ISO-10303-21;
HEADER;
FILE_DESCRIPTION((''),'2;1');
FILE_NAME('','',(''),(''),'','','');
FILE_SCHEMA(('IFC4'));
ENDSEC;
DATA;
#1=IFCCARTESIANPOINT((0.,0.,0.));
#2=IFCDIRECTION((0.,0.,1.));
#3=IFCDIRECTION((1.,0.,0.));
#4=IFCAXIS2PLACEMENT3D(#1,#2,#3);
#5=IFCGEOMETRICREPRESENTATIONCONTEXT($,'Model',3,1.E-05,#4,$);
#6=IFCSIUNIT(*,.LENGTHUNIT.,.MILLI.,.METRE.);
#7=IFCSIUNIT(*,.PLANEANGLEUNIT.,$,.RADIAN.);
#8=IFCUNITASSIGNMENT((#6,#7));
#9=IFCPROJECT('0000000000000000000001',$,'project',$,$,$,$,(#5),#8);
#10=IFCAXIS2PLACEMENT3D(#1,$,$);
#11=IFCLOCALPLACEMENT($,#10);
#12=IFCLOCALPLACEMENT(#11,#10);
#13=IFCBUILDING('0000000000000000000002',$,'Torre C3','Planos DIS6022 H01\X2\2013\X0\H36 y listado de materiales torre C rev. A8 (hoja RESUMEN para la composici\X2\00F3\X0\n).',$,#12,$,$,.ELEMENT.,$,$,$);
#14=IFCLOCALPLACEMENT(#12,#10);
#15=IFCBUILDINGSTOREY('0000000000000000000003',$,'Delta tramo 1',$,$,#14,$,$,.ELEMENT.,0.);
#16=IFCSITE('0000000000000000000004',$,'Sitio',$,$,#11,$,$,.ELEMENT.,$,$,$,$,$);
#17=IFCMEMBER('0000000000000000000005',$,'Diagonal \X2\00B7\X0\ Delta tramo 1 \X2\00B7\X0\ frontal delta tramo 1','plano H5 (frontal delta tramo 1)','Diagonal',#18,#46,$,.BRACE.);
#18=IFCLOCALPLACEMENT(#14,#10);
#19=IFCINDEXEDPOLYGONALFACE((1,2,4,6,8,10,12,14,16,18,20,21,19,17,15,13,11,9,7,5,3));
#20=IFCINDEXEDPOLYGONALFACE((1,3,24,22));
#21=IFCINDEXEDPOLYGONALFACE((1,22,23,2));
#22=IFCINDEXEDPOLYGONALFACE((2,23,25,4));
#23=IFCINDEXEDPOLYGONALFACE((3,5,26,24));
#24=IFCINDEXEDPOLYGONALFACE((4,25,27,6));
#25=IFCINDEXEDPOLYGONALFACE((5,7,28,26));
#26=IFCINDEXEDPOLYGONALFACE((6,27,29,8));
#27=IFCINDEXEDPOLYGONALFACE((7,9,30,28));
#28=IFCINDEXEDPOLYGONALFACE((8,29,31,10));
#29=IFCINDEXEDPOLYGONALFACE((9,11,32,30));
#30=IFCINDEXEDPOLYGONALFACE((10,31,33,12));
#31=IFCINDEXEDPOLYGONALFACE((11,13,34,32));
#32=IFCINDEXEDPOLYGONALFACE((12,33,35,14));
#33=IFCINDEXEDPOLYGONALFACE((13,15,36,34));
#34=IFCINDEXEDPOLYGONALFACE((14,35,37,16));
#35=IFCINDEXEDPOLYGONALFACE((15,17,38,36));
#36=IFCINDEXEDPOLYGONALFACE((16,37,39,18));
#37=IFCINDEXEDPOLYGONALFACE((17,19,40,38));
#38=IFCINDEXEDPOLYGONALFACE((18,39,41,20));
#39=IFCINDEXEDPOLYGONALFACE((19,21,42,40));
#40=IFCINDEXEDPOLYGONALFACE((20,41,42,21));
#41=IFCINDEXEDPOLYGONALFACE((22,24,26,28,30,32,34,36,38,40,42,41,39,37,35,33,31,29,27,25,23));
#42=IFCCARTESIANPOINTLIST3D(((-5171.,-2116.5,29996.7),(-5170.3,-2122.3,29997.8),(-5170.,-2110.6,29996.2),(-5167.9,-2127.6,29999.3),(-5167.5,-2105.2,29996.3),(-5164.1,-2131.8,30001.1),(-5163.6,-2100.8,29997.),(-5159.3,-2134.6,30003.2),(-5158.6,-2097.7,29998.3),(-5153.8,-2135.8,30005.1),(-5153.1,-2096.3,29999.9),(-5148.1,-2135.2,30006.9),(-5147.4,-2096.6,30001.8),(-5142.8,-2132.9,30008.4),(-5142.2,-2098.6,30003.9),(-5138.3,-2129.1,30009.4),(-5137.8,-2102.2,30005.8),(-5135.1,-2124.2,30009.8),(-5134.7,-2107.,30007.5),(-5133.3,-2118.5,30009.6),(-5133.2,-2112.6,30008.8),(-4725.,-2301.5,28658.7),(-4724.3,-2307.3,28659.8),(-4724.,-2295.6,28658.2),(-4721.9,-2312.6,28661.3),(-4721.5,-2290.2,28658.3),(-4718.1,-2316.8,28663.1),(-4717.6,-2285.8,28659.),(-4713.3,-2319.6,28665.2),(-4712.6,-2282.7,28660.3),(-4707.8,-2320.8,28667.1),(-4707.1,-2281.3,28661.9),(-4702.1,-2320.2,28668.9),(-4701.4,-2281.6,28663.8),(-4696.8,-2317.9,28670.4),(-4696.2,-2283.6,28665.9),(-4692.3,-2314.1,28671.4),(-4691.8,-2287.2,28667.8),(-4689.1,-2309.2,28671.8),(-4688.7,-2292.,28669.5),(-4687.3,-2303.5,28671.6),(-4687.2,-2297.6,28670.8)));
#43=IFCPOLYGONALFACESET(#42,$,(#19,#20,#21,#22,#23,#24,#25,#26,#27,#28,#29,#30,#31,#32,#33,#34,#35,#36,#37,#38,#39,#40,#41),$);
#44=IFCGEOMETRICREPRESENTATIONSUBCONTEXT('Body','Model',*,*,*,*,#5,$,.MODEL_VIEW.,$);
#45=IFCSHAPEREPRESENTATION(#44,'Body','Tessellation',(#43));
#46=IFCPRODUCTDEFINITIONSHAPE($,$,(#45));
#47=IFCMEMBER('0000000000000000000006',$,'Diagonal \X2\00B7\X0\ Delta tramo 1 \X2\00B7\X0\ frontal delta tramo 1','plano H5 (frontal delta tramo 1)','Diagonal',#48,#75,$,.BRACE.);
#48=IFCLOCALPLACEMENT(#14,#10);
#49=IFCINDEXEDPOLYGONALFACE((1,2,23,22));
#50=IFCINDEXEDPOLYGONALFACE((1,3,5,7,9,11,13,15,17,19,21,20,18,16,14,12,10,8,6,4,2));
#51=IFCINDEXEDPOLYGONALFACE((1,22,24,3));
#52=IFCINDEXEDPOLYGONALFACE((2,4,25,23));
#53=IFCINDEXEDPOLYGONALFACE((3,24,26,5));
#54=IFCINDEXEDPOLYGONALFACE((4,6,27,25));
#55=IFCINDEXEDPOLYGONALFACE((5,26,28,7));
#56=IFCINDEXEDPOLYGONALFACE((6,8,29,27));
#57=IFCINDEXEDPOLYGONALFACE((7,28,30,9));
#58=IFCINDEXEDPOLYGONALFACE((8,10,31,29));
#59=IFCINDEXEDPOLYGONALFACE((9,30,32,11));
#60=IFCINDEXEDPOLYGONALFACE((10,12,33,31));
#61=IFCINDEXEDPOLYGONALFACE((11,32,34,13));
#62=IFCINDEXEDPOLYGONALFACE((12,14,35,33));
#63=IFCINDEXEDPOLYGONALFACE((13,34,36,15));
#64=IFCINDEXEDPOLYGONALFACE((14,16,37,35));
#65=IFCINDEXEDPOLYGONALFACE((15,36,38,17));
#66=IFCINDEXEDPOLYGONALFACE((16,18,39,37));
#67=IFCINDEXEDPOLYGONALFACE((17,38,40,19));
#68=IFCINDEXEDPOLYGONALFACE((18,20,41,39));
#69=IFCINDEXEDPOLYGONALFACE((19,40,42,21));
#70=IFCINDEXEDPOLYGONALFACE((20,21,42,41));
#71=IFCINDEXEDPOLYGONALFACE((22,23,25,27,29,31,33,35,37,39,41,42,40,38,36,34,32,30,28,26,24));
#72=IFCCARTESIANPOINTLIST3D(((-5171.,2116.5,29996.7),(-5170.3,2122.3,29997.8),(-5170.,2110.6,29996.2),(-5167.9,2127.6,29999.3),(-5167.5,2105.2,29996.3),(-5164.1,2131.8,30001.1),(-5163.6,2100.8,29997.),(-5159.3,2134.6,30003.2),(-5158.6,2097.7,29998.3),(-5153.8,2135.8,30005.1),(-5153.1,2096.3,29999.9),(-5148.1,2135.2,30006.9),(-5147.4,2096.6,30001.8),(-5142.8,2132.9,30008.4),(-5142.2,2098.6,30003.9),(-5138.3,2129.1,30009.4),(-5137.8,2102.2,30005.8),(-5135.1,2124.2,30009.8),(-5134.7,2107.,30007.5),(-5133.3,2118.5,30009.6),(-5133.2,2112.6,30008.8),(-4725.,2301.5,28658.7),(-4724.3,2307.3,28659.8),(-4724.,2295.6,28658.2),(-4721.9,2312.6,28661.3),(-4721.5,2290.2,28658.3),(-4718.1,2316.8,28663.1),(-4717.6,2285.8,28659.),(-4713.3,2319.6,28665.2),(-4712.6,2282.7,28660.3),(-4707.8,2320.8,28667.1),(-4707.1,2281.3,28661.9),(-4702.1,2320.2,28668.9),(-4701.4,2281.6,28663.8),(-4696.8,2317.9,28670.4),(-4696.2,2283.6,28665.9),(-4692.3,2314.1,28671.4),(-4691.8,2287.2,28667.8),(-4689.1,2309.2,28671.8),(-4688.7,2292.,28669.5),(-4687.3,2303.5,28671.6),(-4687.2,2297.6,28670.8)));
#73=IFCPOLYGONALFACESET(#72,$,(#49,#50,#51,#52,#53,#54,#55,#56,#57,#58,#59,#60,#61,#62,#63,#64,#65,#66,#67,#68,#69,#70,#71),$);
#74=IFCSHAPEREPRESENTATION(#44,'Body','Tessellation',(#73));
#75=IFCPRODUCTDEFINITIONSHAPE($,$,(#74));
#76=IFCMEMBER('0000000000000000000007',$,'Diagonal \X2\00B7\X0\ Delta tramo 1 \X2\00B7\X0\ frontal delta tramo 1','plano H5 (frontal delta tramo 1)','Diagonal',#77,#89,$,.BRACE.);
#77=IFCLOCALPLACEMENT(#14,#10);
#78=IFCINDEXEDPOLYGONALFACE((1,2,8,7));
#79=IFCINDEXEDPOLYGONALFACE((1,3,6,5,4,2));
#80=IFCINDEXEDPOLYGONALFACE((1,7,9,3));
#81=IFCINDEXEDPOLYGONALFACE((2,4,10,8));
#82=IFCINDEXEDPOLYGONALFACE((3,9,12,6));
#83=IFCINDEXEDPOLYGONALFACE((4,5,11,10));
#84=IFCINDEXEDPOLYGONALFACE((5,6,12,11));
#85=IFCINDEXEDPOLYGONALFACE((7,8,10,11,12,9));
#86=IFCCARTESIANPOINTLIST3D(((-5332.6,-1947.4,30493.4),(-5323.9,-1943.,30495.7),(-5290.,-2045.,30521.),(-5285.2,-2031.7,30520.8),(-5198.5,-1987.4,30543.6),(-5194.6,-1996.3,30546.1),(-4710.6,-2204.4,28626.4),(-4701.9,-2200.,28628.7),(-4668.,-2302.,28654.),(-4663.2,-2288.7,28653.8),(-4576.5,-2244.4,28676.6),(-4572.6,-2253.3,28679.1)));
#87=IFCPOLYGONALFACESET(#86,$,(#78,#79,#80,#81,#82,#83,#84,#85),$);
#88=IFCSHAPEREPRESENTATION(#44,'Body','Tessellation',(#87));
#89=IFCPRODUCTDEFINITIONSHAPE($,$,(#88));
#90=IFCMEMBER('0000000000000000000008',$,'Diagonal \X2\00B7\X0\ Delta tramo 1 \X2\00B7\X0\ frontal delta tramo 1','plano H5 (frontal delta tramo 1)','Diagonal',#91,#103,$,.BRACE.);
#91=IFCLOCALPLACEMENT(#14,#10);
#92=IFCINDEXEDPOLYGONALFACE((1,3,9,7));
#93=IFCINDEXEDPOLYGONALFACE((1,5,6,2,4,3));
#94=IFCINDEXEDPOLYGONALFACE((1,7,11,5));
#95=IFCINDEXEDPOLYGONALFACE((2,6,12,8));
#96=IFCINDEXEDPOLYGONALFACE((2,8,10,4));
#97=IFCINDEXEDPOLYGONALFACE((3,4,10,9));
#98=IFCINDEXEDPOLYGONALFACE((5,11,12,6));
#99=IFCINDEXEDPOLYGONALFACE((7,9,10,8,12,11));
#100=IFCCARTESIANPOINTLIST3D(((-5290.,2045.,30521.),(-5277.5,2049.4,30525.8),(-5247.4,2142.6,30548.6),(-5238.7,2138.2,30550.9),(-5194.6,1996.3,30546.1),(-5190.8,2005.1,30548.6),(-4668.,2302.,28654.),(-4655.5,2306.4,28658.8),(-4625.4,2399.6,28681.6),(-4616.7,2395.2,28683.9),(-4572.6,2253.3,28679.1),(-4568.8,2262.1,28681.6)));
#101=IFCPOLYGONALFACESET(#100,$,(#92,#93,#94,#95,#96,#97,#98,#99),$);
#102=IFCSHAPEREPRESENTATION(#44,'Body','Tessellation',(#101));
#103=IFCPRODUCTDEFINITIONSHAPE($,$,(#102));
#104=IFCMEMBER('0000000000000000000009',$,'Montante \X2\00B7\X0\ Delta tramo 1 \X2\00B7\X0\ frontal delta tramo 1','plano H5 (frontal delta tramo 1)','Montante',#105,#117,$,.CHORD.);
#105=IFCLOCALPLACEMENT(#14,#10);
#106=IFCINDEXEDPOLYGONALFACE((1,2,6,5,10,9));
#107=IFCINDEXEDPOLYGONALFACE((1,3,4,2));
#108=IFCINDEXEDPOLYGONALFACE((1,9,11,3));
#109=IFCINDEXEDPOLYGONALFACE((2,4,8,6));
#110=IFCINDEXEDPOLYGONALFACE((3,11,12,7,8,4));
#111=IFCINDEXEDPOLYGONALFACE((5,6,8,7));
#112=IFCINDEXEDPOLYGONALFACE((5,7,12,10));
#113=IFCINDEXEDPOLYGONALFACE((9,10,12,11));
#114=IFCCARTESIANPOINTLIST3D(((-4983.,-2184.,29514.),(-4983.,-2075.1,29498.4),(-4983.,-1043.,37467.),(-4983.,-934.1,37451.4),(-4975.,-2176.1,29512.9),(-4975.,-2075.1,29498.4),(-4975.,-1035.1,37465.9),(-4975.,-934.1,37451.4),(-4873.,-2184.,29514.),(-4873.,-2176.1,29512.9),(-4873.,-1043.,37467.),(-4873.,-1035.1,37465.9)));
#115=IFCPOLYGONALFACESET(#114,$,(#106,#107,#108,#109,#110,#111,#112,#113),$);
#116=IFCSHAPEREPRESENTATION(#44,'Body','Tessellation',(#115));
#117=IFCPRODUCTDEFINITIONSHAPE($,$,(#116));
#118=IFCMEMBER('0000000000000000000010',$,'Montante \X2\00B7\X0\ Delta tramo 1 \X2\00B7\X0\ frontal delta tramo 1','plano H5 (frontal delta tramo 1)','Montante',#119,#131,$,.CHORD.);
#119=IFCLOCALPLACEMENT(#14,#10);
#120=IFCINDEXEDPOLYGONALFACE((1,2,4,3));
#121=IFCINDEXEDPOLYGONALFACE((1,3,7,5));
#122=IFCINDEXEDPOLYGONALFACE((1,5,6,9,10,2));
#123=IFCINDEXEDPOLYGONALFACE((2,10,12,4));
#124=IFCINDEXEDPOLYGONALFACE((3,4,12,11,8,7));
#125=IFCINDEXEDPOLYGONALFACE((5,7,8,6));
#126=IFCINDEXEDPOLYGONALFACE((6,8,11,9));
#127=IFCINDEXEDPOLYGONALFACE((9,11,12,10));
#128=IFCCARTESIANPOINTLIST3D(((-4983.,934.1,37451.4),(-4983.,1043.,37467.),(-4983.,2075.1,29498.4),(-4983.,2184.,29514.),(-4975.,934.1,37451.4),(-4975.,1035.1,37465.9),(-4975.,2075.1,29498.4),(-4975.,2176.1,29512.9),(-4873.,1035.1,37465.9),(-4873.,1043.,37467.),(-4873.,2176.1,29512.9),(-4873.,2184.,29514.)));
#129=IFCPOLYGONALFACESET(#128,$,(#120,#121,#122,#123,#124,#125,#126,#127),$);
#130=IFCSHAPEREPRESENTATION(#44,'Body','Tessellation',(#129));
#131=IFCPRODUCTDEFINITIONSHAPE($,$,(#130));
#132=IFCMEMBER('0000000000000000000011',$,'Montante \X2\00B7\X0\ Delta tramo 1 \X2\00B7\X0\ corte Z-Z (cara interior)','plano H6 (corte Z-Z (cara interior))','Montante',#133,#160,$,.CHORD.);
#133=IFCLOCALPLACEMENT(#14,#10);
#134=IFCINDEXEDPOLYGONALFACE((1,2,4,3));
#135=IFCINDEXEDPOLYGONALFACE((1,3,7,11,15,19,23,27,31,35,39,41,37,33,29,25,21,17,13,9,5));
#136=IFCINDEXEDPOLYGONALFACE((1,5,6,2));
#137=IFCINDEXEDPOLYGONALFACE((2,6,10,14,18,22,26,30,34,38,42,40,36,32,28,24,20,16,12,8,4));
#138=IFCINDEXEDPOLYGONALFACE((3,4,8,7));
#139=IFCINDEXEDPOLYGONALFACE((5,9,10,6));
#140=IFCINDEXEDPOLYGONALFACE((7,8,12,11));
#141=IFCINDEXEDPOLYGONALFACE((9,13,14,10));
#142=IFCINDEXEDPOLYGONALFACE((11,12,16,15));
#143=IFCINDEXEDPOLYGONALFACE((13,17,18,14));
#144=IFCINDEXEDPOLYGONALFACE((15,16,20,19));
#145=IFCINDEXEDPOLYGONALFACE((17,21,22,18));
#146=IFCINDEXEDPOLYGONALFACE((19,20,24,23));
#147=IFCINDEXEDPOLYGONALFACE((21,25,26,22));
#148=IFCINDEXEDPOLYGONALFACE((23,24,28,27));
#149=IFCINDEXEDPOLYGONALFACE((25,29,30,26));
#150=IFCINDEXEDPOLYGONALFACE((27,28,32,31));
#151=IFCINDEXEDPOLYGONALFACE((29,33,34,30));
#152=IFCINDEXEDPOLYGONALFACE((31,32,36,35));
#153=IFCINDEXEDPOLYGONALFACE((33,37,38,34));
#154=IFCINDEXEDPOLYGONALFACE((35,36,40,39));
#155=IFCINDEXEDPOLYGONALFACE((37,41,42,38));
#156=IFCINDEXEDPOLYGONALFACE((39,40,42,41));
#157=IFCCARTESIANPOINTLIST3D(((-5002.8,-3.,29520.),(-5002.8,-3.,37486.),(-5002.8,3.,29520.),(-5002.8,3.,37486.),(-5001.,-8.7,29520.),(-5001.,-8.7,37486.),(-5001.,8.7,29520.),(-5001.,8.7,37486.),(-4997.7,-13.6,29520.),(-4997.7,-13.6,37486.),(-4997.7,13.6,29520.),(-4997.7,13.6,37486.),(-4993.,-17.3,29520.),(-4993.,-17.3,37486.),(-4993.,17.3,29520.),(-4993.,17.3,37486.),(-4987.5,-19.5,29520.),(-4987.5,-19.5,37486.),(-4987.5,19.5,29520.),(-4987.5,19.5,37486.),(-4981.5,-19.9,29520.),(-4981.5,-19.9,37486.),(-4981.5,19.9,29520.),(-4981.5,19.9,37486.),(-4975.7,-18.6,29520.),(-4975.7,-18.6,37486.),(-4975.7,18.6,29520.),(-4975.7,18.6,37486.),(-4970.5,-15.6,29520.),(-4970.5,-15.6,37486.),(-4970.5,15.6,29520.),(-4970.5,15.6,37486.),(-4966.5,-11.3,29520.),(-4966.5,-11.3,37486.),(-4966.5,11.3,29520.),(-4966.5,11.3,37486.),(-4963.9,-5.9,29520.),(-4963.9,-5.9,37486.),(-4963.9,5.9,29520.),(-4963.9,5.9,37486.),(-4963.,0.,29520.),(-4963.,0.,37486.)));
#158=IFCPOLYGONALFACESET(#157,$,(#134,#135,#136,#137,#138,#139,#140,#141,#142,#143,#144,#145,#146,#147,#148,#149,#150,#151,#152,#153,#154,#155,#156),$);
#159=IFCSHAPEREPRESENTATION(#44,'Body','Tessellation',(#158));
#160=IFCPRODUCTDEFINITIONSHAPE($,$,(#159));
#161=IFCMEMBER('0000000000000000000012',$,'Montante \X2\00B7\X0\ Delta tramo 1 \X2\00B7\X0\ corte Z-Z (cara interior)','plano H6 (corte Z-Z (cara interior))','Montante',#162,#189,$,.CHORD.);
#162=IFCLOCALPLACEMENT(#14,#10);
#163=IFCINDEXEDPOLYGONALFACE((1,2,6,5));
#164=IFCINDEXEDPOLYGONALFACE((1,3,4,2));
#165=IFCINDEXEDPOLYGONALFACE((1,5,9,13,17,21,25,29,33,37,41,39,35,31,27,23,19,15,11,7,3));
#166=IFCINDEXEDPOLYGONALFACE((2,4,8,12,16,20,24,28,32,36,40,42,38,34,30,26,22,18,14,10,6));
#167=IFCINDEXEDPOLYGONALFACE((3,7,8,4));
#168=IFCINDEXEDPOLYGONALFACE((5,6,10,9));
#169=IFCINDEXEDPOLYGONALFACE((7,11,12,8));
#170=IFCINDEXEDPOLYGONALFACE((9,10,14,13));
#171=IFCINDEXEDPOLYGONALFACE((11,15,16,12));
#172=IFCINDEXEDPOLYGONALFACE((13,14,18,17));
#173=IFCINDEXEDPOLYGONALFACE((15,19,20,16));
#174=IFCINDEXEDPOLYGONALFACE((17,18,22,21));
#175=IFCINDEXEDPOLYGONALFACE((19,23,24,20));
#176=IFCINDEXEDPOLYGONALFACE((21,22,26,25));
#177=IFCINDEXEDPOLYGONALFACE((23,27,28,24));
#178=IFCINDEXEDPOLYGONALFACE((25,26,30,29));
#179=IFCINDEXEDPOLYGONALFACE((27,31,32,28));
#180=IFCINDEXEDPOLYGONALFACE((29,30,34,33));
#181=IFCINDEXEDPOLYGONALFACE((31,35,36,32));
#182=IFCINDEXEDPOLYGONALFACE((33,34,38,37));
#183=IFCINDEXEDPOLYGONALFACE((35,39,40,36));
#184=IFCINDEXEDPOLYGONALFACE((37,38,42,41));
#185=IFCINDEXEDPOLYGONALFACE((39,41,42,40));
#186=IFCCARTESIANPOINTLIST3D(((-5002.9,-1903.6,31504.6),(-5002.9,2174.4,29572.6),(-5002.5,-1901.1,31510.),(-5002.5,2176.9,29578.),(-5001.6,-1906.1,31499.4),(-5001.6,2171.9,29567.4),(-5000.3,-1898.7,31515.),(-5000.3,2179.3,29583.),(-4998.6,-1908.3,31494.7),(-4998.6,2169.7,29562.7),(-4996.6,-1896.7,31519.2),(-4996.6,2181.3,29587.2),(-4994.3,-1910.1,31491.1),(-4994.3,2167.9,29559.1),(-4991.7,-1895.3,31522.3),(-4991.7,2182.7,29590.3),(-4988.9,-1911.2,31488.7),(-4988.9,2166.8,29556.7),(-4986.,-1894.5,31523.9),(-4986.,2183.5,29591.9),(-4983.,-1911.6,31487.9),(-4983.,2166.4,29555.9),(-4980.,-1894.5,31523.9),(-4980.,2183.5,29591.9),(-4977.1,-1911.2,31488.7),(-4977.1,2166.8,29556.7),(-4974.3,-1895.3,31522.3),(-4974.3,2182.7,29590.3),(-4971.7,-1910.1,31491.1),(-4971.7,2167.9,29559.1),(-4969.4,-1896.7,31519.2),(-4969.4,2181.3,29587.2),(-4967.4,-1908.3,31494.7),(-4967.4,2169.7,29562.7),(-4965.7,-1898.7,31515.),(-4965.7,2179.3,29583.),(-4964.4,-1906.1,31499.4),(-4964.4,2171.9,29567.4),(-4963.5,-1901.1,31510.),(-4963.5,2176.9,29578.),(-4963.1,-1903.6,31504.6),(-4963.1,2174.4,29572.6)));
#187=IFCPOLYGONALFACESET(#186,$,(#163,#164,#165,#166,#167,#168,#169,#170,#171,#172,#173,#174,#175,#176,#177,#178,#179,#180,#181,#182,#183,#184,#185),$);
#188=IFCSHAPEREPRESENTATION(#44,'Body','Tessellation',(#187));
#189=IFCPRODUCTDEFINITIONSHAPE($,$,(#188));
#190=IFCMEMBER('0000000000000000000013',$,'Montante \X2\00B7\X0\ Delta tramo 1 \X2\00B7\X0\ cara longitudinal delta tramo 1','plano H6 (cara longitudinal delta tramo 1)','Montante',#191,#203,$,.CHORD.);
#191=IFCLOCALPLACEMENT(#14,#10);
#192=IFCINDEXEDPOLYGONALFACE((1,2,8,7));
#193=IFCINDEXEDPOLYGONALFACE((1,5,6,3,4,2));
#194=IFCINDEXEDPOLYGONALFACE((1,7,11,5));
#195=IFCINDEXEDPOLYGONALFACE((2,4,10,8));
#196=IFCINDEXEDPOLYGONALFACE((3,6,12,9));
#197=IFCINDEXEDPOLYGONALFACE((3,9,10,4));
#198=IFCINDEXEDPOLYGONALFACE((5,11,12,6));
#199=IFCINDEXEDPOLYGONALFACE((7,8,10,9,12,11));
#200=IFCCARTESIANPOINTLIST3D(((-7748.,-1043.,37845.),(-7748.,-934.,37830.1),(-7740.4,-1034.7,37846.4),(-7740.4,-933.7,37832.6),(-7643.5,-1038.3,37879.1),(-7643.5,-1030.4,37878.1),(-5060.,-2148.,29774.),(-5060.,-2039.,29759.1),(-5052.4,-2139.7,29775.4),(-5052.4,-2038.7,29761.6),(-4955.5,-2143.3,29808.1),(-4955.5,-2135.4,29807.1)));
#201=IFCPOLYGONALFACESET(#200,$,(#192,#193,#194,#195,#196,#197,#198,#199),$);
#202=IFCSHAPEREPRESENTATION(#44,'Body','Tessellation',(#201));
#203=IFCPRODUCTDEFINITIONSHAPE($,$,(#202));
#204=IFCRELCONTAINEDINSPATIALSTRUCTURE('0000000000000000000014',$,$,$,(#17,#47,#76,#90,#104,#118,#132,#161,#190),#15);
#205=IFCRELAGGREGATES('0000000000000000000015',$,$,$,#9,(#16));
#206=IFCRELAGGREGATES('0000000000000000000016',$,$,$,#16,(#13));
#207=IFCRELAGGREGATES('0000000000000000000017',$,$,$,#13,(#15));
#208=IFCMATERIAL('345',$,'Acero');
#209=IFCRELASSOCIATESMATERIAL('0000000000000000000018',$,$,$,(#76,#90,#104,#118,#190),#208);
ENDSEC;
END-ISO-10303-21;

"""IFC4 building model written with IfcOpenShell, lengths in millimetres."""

from ifc_helpers import new_model, si_unit, frame, frame_2d, origin, origin_with_axes, place, context, subcontext, project, spatial, circle, l_section, extrude, material, element, save


model = new_model("IFC4")

# Units and contexts
model_context = context("Model", 3, precision=1e-05, world=origin_with_axes())
body_context = subcontext(model_context, "Body", "Model", "MODEL_VIEW")
ifc_project = project(units=[si_unit("LENGTHUNIT", "METRE", prefix="MILLI"), si_unit("PLANEANGLEUNIT", "RADIAN")], contexts=[model_context])

# Site, building, storey
site_placement = place(None, origin())
site = spatial("IfcSite", under=ifc_project, at=site_placement, Name="Sitio", CompositionType="ELEMENT")
building_placement = place(site_placement, origin())
building = spatial("IfcBuilding", under=site, at=building_placement, Name="Torre C3", Description="Planos DIS6022 H01–H36 y listado de materiales torre C rev. A8 (hoja RESUMEN para la composición).", CompositionType="ELEMENT")
storey_placement = place(building_placement, origin())
storey = spatial("IfcBuildingStorey", under=building, at=storey_placement, Name="Delta tramo 1", CompositionType="ELEMENT", Elevation=0.0)

# Members
for number, where, z_axis, x_axis, name in (
    (1, (-4706.0, -2301.0, 28665.0), (-0.313542, 0.130057, 0.940626), (0.863292, 0.451616, 0.225321), "Diagonal · Delta tramo 1 · frontal delta tramo 1"),
    (2, (-4706.0, 2301.0, 28665.0), (-0.313542, -0.130057, 0.940626), (0.863292, -0.451616, 0.225321), "Diagonal · Delta tramo 1 · frontal delta tramo 1"),
):
    element("IfcMember", number, at=place(storey_placement, frame(where, z_axis=z_axis, x_axis=x_axis)), inside=storey, Name=name, Description="plano H5 (frontal delta tramo 1)", ObjectType="Diagonal", PredefinedType="BRACE", context=body_context, shape_type="SweptSolid", body=[
        extrude(circle(Radius=20.0), None, (0.0, 0.0, 1.0), 1422.5),
    ])
ifc_material_1 = material(Name="345", Category="Acero")
for number, where, z_axis, x_axis, name in (
    (3, (-4668.0, -2302.0, 28654.0), (-0.313414, 0.129497, 0.940746), (0.867067, 0.443015, 0.227885), "Diagonal · Delta tramo 1 · frontal delta tramo 1"),
    (4, (-4668.0, 2302.0, 28654.0), (-0.313414, -0.129497, 0.940746), (0.867067, -0.443015, 0.227885), "Diagonal · Delta tramo 1 · frontal delta tramo 1"),
):
    element("IfcMember", number, at=place(storey_placement, frame(where, z_axis=z_axis, x_axis=x_axis)), inside=storey, material=ifc_material_1, Name=name, Description="plano H5 (frontal delta tramo 1)", ObjectType="Diagonal", PredefinedType="BRACE", context=body_context, shape_type="SweptSolid", body=[
        extrude(l_section(Depth=110.0, Width=110.0, Thickness=10.0, at=frame_2d((55.0, 55.0))), None, (0.0, 0.0, 1.0), 1984.6),
    ])
for number, where, z_axis, x_axis, name in (
    (5, (-4983.0, -2184.0, 29514.0), (0.0, 0.142014, 0.989865), (1.0, 0.0, 0.0), "Montante · Delta tramo 1 · frontal delta tramo 1"),
    (6, (-4983.0, 2184.0, 29514.0), (0.0, -0.142014, 0.989865), (0.0, -0.989865, -0.142014), "Montante · Delta tramo 1 · frontal delta tramo 1"),
):
    element("IfcMember", number, at=place(storey_placement, frame(where, z_axis=z_axis, x_axis=x_axis)), inside=storey, material=ifc_material_1, Name=name, Description="plano H5 (frontal delta tramo 1)", ObjectType="Montante", PredefinedType="CHORD", context=body_context, shape_type="SweptSolid", body=[
        extrude(l_section(Depth=110.0, Width=110.0, Thickness=8.0, at=frame_2d((55.0, 55.0))), None, (0.0, 0.0, 1.0), 8034.4),
    ])
member_1_placement = place(storey_placement, frame((-4983.0, 0.0, 29520.0), z_axis=(0.0, 0.0, 1.0), x_axis=(1.0, 0.0, 0.0)))
element("IfcMember", 7, at=member_1_placement, inside=storey, Name="Montante · Delta tramo 1 · corte Z-Z (cara interior)", Description="plano H6 (corte Z-Z (cara interior))", ObjectType="Montante", PredefinedType="CHORD", context=body_context, shape_type="SweptSolid", body=[
    extrude(circle(Radius=20.0), None, (0.0, 0.0, 1.0), 7966.0),
])
member_2_placement = place(storey_placement, frame((-4983.0, 2175.0, 29574.0), z_axis=(0.0, -0.903711, 0.428144), x_axis=(0.0, -0.428144, -0.903711)))
element("IfcMember", 8, at=member_2_placement, inside=storey, Name="Montante · Delta tramo 1 · corte Z-Z (cara interior)", Description="plano H6 (corte Z-Z (cara interior))", ObjectType="Montante", PredefinedType="CHORD", context=body_context, shape_type="SweptSolid", body=[
    extrude(circle(Radius=20.0), None, (0.0, 0.0, 1.0), 4512.5),
])
member_3_placement = place(storey_placement, frame((-5060.0, -2148.0, 29774.0), z_axis=(-0.313348, 0.128813, 0.940861), x_axis=(0.949638, 0.042504, 0.310452)))
element("IfcMember", 9, at=member_3_placement, inside=storey, material=ifc_material_1, Name="Montante · Delta tramo 1 · cara longitudinal delta tramo 1", Description="plano H6 (cara longitudinal delta tramo 1)", ObjectType="Montante", PredefinedType="CHORD", context=body_context, shape_type="SweptSolid", body=[
    extrude(l_section(Depth=110.0, Width=110.0, Thickness=8.0, at=frame_2d((55.0, 55.0))), None, (0.0, 0.0, 1.0), 8578.3),
])

save(model, "model.ifc")
